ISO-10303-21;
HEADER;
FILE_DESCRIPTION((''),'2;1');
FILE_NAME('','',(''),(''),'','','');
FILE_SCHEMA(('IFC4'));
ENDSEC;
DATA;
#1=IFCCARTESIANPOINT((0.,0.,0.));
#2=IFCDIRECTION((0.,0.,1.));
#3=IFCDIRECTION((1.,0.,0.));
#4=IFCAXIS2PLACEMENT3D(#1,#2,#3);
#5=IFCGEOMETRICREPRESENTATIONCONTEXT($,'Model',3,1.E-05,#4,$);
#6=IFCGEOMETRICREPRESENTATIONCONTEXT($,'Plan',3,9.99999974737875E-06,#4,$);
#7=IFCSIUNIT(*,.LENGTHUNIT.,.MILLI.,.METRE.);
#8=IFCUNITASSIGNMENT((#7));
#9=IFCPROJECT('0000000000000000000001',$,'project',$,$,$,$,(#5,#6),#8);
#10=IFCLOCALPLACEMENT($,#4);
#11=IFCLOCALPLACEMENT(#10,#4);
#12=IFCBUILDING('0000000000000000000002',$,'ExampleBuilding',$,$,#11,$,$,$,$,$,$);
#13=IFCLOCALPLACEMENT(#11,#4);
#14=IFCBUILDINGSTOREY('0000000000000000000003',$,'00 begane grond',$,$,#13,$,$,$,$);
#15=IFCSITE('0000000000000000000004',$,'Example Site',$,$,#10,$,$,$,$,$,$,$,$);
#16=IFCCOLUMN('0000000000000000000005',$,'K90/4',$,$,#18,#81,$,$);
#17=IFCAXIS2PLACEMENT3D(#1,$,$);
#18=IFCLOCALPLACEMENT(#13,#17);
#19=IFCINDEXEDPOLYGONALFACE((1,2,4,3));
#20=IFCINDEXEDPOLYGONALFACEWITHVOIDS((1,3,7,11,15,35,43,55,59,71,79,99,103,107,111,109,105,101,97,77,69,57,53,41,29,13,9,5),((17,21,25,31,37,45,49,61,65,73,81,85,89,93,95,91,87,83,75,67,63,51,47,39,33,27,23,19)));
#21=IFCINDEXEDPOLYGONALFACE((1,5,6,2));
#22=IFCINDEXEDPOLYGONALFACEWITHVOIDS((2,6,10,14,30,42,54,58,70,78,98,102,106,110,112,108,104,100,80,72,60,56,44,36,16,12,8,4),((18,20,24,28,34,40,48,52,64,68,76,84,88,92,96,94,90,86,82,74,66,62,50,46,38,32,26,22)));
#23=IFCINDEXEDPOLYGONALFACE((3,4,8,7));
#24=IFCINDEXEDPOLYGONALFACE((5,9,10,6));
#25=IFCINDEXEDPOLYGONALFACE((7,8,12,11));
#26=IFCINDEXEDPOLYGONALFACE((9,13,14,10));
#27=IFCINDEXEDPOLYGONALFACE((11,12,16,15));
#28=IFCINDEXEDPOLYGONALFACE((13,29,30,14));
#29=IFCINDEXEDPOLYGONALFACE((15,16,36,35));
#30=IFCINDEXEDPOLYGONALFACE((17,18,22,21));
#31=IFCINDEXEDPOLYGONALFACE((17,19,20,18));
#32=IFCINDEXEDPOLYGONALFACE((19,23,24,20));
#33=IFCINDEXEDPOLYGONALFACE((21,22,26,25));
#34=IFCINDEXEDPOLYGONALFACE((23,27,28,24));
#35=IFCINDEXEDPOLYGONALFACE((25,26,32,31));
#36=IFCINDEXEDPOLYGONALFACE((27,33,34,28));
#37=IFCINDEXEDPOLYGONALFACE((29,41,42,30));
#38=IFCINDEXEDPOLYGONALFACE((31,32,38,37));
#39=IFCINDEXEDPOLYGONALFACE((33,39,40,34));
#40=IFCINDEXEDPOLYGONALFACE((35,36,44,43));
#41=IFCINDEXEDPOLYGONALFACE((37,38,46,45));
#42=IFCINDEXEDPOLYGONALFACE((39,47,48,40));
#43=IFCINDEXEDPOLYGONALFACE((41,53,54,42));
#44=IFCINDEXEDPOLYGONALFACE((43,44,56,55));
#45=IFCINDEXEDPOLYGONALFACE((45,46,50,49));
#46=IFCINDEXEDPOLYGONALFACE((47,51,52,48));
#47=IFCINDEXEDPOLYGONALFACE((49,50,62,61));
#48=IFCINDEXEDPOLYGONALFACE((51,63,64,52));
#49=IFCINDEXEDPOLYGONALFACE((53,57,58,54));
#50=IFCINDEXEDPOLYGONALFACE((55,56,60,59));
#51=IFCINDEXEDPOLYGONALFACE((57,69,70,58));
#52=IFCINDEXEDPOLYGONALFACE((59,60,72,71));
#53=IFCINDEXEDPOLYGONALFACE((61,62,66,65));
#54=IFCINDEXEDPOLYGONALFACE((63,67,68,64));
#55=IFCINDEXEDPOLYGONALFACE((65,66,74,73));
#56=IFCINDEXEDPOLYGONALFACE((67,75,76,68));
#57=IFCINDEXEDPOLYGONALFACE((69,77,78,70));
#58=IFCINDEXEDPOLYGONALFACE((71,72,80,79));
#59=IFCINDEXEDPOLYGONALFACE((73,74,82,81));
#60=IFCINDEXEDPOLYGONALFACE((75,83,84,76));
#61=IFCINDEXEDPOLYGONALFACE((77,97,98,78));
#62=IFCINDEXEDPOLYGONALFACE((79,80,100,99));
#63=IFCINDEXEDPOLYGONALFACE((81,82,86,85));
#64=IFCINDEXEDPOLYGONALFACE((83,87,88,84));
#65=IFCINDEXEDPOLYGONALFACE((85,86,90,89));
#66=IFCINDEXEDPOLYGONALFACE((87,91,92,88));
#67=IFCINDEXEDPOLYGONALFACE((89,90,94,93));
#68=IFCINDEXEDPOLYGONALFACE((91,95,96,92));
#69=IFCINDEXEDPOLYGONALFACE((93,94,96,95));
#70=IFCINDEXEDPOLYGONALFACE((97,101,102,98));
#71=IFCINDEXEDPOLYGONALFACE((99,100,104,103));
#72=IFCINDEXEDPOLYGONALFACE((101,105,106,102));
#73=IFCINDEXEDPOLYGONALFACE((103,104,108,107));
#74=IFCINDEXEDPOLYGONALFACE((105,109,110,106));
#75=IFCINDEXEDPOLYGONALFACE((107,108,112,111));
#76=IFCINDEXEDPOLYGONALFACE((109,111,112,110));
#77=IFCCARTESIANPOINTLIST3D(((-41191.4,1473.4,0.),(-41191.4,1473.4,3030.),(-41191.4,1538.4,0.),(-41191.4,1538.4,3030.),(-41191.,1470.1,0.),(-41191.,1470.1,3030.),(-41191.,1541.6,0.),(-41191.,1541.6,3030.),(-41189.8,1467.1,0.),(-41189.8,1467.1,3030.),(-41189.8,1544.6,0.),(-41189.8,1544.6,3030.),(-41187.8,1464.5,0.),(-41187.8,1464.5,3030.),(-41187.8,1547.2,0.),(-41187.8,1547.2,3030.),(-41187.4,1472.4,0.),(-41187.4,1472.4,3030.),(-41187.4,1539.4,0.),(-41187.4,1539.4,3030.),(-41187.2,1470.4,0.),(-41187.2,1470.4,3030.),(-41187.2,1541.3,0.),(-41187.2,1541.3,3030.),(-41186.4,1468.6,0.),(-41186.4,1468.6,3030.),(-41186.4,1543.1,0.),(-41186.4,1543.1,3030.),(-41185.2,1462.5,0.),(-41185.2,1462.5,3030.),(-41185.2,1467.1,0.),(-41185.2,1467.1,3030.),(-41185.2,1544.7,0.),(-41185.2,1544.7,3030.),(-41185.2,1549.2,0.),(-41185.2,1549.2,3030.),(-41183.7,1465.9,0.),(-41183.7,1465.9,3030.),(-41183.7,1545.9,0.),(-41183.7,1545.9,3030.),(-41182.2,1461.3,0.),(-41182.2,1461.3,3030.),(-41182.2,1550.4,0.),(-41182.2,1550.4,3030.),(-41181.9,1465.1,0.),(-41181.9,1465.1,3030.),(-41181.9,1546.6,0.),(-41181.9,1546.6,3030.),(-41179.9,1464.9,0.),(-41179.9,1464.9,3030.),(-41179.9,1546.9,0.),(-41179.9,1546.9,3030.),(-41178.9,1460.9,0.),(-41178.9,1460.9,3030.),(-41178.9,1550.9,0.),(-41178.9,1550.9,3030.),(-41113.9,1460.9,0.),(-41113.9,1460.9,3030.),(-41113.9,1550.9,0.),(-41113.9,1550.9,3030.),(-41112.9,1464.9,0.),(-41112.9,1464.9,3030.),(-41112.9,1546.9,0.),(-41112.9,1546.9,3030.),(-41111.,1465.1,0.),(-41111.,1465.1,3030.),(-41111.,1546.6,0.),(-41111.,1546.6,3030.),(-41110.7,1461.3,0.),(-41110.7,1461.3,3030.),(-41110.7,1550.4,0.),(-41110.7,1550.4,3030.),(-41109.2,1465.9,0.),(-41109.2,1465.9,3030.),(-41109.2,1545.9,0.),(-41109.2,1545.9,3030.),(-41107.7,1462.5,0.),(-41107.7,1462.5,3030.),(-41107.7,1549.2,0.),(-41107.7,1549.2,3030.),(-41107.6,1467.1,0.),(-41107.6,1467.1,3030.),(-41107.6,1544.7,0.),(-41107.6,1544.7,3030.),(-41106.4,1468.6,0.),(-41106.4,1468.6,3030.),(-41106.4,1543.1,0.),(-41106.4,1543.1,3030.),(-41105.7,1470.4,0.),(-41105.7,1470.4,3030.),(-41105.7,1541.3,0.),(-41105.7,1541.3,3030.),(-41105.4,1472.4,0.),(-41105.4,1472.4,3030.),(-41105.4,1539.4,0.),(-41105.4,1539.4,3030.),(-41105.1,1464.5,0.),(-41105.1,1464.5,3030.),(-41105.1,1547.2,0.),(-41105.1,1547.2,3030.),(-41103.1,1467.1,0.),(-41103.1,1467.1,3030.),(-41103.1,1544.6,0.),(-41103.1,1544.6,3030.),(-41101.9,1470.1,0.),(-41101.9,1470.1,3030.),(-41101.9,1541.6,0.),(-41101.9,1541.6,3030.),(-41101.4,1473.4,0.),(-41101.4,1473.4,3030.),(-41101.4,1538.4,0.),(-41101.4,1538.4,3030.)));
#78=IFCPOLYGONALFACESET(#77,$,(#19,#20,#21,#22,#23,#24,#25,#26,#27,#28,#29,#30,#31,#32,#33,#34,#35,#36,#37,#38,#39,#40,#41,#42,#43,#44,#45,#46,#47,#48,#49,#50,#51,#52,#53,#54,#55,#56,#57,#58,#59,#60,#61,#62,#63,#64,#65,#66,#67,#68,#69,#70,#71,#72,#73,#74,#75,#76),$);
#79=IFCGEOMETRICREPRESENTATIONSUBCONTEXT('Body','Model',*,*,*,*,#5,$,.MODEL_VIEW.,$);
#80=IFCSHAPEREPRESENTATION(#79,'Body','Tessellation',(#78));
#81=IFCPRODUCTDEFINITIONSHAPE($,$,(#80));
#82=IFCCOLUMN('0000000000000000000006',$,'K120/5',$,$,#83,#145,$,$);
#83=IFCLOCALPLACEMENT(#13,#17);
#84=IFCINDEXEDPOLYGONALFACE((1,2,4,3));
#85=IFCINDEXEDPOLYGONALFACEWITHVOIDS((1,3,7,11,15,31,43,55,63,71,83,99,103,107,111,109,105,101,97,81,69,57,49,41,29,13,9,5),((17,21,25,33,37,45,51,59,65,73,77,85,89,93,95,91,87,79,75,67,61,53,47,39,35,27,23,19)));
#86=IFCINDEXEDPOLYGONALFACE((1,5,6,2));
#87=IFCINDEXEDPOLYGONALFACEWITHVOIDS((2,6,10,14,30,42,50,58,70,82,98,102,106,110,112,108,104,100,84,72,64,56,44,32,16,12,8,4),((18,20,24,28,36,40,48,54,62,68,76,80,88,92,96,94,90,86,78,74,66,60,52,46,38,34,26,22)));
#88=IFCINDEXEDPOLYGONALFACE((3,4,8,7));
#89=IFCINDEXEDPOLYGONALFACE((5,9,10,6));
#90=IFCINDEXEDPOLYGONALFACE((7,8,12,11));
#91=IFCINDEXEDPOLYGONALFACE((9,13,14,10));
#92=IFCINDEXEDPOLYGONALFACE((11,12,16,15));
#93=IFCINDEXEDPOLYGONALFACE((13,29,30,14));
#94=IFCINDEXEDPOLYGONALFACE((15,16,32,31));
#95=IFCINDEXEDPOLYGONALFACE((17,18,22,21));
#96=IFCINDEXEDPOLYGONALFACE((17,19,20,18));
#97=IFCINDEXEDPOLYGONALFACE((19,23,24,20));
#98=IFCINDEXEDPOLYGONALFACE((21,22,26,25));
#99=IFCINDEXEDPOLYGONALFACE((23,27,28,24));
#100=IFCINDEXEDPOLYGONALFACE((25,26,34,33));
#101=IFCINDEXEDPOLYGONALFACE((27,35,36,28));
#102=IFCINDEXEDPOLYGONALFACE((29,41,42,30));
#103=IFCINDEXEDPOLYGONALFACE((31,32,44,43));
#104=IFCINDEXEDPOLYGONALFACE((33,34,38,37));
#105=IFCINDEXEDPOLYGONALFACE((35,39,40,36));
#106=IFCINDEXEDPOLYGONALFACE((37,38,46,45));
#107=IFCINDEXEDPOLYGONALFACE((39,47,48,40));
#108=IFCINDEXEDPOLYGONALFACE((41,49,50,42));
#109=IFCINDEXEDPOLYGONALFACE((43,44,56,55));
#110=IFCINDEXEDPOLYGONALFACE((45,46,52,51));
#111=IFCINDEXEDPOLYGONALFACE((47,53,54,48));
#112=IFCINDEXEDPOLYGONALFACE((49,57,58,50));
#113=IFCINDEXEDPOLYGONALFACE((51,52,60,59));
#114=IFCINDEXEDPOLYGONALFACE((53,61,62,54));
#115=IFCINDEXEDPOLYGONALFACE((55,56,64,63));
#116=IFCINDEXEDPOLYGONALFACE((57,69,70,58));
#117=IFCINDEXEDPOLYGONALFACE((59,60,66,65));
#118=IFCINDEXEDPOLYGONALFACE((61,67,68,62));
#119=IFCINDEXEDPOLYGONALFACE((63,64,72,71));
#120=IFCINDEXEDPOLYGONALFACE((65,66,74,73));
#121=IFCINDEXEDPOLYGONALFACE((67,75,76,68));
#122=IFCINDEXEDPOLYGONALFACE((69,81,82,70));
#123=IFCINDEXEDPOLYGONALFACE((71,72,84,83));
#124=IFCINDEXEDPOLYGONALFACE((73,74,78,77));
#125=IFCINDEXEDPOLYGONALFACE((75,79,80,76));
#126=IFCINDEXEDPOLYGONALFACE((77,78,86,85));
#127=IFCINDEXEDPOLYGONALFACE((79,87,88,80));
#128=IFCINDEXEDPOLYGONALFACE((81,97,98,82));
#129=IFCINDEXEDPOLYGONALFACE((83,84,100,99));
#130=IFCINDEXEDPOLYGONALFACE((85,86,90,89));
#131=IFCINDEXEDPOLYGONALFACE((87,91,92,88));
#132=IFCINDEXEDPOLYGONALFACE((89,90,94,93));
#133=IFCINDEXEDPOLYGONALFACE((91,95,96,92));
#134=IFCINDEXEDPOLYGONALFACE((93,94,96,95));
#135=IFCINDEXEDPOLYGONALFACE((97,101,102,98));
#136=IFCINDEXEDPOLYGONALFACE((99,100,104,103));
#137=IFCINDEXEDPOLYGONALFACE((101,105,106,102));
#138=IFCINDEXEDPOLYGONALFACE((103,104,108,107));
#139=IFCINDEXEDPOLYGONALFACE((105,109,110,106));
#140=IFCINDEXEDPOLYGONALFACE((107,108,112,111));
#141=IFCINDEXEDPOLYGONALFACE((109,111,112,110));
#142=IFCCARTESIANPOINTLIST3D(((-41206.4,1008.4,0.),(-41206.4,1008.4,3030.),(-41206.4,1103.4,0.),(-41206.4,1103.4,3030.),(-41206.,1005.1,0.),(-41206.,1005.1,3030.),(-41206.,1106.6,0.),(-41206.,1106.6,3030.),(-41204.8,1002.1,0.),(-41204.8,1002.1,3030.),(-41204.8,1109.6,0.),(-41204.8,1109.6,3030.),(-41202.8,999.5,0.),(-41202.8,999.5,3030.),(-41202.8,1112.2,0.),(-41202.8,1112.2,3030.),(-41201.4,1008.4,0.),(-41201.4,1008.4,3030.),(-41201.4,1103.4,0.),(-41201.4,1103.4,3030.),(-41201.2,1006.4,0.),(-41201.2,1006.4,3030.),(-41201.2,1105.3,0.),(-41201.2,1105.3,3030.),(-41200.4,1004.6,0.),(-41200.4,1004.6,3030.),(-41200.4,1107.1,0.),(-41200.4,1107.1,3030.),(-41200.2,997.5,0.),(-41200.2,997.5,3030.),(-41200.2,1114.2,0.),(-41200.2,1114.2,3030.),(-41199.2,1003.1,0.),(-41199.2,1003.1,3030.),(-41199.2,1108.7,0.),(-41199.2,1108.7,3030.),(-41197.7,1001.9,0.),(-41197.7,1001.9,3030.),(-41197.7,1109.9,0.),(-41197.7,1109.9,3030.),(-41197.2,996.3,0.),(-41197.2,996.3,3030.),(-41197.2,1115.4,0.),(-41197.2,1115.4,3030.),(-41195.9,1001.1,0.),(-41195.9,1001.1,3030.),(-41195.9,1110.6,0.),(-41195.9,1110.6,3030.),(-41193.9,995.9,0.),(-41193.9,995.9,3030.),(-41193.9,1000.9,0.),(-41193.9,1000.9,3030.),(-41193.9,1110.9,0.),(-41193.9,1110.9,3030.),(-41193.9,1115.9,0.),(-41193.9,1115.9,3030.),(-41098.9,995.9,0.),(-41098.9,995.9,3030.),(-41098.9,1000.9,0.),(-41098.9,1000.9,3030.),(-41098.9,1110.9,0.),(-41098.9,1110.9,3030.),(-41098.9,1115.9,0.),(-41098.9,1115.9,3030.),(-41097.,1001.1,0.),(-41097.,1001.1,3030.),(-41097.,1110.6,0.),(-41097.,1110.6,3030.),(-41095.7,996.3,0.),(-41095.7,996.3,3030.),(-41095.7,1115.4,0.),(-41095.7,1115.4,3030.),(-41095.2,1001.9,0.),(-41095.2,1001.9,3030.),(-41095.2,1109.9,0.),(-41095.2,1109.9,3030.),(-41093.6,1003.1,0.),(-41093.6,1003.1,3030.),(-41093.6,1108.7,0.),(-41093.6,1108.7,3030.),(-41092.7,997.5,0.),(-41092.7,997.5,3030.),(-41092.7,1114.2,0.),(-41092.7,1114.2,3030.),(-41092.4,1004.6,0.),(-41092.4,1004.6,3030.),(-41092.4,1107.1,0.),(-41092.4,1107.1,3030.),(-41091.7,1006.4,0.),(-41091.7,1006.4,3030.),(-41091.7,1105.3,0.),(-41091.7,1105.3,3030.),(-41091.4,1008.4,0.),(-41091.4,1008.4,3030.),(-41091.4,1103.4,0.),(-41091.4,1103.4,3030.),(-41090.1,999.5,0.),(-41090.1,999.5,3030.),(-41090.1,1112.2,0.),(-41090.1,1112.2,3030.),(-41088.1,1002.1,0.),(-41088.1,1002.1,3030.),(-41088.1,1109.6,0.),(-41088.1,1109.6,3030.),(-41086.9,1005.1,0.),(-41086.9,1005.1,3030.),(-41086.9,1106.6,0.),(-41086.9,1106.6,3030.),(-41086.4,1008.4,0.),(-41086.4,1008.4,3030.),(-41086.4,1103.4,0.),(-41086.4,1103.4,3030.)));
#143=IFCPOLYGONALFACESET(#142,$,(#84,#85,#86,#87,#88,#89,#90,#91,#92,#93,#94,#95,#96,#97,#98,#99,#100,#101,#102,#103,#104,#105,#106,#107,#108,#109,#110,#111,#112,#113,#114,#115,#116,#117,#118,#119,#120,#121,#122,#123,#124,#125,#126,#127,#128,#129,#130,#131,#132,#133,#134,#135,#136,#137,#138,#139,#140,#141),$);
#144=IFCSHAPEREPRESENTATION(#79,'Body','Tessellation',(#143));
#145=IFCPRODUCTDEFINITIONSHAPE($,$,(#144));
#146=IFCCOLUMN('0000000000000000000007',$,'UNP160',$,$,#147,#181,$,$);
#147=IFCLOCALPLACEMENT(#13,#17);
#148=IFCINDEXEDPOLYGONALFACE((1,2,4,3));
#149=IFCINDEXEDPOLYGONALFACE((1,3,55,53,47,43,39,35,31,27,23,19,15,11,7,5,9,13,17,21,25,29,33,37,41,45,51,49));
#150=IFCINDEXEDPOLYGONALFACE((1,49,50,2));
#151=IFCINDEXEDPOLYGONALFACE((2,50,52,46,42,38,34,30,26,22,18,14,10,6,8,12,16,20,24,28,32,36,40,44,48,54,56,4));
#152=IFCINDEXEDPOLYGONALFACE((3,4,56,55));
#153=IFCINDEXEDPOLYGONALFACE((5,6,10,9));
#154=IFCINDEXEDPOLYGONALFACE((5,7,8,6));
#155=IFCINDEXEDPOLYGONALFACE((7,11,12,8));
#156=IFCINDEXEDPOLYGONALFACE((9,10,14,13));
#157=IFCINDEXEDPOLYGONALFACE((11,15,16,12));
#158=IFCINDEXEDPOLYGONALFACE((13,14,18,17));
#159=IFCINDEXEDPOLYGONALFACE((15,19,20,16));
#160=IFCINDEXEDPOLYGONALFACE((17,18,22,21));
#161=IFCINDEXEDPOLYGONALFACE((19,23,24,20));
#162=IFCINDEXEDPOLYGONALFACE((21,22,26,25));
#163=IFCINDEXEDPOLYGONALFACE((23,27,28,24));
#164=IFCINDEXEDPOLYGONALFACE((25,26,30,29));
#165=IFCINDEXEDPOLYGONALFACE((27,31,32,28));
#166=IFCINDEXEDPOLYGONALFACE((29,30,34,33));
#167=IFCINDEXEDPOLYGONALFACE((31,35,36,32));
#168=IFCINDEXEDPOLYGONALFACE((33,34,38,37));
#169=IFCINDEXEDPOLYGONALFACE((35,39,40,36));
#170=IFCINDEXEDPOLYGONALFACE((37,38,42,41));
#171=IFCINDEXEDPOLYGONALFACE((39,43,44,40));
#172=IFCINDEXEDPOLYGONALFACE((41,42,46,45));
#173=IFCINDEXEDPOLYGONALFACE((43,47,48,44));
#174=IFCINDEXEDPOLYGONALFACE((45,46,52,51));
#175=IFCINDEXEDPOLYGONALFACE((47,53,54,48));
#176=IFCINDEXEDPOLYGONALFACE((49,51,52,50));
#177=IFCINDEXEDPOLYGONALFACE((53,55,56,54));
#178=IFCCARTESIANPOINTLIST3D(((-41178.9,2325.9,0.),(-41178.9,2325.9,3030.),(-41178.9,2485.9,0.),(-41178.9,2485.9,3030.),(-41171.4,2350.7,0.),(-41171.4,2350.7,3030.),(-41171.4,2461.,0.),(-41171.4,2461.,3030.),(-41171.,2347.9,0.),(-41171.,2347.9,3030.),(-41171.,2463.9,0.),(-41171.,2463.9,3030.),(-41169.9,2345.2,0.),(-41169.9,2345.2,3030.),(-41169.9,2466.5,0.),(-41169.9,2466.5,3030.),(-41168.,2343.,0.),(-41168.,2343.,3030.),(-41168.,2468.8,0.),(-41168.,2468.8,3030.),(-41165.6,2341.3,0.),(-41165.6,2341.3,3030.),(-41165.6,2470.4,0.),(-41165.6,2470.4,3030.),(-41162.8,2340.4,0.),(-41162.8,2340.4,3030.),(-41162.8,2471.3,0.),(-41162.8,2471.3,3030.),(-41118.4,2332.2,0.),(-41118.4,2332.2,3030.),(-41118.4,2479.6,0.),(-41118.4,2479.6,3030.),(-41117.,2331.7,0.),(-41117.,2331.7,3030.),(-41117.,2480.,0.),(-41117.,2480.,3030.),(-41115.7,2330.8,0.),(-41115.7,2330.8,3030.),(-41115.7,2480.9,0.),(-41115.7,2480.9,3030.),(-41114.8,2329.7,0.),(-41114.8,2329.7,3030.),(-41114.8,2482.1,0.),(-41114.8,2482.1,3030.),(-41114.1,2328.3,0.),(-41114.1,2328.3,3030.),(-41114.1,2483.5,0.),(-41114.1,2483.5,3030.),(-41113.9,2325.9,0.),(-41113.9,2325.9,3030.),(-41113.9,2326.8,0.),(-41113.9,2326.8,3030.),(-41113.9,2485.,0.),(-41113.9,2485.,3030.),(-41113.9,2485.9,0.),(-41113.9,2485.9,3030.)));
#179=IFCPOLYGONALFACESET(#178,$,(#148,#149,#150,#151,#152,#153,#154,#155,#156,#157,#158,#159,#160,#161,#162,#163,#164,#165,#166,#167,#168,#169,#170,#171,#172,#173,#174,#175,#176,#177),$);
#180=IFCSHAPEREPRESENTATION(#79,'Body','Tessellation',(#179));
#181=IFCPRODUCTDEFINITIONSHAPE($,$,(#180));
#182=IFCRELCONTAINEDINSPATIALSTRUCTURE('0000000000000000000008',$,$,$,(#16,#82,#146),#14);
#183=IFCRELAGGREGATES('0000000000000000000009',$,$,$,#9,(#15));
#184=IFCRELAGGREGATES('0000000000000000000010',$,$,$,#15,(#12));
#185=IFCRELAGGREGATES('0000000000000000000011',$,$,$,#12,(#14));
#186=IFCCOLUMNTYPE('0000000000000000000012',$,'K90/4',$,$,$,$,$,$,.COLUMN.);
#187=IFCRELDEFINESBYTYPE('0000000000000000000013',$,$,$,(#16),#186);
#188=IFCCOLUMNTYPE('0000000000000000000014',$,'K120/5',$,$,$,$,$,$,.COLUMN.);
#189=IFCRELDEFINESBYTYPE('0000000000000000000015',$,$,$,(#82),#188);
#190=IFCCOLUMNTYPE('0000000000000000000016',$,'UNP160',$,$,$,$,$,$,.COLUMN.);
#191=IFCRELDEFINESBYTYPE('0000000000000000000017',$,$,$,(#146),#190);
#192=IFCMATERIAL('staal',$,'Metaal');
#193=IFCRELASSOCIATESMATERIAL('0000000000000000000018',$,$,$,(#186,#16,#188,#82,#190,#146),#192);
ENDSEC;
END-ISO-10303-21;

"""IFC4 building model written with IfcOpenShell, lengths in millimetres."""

from ifc_helpers import new_model, si_unit, frame, origin_with_axes, place, context, subcontext, project, spatial, hollow_rectangle, u_section, extrude, material, material_profile, profile_set, profile_usage, type_object, element, save


model = new_model("IFC4")

# Units and contexts
model_context = context("Model", 3, precision=1e-05, world=origin_with_axes())
plan_context = context("Plan", 3, precision=9.99999974737875e-06, world=origin_with_axes())
body_context = subcontext(model_context, "Body", "Model", "MODEL_VIEW")
ifc_project = project(units=[si_unit("LENGTHUNIT", "METRE", prefix="MILLI")], contexts=[model_context, plan_context])

# Site, building, storey
site_placement = place(None, frame((0.0, 0.0, 0.0), z_axis=(0.0, 0.0, 1.0), x_axis=(1.0, 0.0, 0.0)))
site = spatial("IfcSite", under=ifc_project, at=site_placement, Name="Example Site")
building_placement = place(site_placement, frame((0.0, 0.0, 0.0), z_axis=(0.0, 0.0, 1.0), x_axis=(1.0, 0.0, 0.0)))
building = spatial("IfcBuilding", under=site, at=building_placement, Name="ExampleBuilding")
storey_placement = place(building_placement, frame((0.0, 0.0, 0.0), z_axis=(0.0, 0.0, 1.0), x_axis=(1.0, 0.0, 0.0)))
storey = spatial("IfcBuildingStorey", under=building, at=storey_placement, Name="00 begane grond")

# Columns
ifc_material_1 = material(Name="staal", Category="Metaal")
ifc_material_profile_1 = material_profile(ifc_material_1, hollow_rectangle(XDim=90.0, YDim=90.0, WallThickness=4.0, InnerFilletRadius=7.5, OuterFilletRadius=12.5))
ifc_profile_set_1 = profile_set([ifc_material_profile_1], Name="staal")
ifc_profile_usage_1 = profile_usage(ifc_profile_set_1)
column_type_1 = type_object("IfcColumnType", Name="K90/4", PredefinedType="COLUMN", material=ifc_profile_set_1)
column_1_placement = place(storey_placement, frame((-41146.4, 1505.9, 0.0), z_axis=(0.0, 0.0, 1.0), x_axis=(1.0, 0.0, 0.0)))
element("IfcColumn", 1, at=column_1_placement, inside=storey, type_object=column_type_1, material=ifc_profile_usage_1, Name="K90/4", context=body_context, shape_type="SweptSolid", body=[
    extrude(hollow_rectangle(XDim=90.0, YDim=90.0, WallThickness=4.0, InnerFilletRadius=7.5, OuterFilletRadius=12.5), origin_with_axes(), (0.0, 0.0, 1.0), 3030.0),
])
ifc_material_profile_2 = material_profile(ifc_material_1, hollow_rectangle(XDim=120.0, YDim=120.0, WallThickness=5.0, InnerFilletRadius=7.5, OuterFilletRadius=12.5))
ifc_profile_set_2 = profile_set([ifc_material_profile_2], Name="staal")
ifc_profile_usage_2 = profile_usage(ifc_profile_set_2)
column_type_2 = type_object("IfcColumnType", Name="K120/5", PredefinedType="COLUMN", material=ifc_profile_set_2)
column_2_placement = place(storey_placement, frame((-41146.4, 1055.9, 0.0), z_axis=(0.0, 0.0, 1.0), x_axis=(1.0, 0.0, 0.0)))
element("IfcColumn", 2, at=column_2_placement, inside=storey, type_object=column_type_2, material=ifc_profile_usage_2, Name="K120/5", context=body_context, shape_type="SweptSolid", body=[
    extrude(hollow_rectangle(XDim=120.0, YDim=120.0, WallThickness=5.0, InnerFilletRadius=7.5, OuterFilletRadius=12.5), origin_with_axes(), (0.0, 0.0, 1.0), 3030.0),
])
ifc_material_profile_3 = material_profile(ifc_material_1, u_section(Depth=160.0, FlangeWidth=65.0, WebThickness=7.5, FlangeThickness=11.5, FilletRadius=10.5, EdgeRadius=5.5, FlangeSlope=6.1, kind="CURVE"))
ifc_profile_set_3 = profile_set([ifc_material_profile_3], Name="staal")
ifc_profile_usage_3 = profile_usage(ifc_profile_set_3)
column_type_3 = type_object("IfcColumnType", Name="UNP160", PredefinedType="COLUMN", material=ifc_profile_set_3)
column_3_placement = place(storey_placement, frame((-41146.4, 2405.9, 0.0), z_axis=(0.0, 0.0, 1.0), x_axis=(1.0, 0.0, 0.0)))
element("IfcColumn", 3, at=column_3_placement, inside=storey, type_object=column_type_3, material=ifc_profile_usage_3, Name="UNP160", context=body_context, shape_type="SweptSolid", body=[
    extrude(u_section(Depth=160.0, FlangeWidth=65.0, WebThickness=7.5, FlangeThickness=11.5, FilletRadius=10.5, EdgeRadius=5.5, FlangeSlope=6.1, kind="CURVE"), origin_with_axes(), (0.0, 0.0, 1.0), 3030.0),
])

save(model, "model.ifc")
